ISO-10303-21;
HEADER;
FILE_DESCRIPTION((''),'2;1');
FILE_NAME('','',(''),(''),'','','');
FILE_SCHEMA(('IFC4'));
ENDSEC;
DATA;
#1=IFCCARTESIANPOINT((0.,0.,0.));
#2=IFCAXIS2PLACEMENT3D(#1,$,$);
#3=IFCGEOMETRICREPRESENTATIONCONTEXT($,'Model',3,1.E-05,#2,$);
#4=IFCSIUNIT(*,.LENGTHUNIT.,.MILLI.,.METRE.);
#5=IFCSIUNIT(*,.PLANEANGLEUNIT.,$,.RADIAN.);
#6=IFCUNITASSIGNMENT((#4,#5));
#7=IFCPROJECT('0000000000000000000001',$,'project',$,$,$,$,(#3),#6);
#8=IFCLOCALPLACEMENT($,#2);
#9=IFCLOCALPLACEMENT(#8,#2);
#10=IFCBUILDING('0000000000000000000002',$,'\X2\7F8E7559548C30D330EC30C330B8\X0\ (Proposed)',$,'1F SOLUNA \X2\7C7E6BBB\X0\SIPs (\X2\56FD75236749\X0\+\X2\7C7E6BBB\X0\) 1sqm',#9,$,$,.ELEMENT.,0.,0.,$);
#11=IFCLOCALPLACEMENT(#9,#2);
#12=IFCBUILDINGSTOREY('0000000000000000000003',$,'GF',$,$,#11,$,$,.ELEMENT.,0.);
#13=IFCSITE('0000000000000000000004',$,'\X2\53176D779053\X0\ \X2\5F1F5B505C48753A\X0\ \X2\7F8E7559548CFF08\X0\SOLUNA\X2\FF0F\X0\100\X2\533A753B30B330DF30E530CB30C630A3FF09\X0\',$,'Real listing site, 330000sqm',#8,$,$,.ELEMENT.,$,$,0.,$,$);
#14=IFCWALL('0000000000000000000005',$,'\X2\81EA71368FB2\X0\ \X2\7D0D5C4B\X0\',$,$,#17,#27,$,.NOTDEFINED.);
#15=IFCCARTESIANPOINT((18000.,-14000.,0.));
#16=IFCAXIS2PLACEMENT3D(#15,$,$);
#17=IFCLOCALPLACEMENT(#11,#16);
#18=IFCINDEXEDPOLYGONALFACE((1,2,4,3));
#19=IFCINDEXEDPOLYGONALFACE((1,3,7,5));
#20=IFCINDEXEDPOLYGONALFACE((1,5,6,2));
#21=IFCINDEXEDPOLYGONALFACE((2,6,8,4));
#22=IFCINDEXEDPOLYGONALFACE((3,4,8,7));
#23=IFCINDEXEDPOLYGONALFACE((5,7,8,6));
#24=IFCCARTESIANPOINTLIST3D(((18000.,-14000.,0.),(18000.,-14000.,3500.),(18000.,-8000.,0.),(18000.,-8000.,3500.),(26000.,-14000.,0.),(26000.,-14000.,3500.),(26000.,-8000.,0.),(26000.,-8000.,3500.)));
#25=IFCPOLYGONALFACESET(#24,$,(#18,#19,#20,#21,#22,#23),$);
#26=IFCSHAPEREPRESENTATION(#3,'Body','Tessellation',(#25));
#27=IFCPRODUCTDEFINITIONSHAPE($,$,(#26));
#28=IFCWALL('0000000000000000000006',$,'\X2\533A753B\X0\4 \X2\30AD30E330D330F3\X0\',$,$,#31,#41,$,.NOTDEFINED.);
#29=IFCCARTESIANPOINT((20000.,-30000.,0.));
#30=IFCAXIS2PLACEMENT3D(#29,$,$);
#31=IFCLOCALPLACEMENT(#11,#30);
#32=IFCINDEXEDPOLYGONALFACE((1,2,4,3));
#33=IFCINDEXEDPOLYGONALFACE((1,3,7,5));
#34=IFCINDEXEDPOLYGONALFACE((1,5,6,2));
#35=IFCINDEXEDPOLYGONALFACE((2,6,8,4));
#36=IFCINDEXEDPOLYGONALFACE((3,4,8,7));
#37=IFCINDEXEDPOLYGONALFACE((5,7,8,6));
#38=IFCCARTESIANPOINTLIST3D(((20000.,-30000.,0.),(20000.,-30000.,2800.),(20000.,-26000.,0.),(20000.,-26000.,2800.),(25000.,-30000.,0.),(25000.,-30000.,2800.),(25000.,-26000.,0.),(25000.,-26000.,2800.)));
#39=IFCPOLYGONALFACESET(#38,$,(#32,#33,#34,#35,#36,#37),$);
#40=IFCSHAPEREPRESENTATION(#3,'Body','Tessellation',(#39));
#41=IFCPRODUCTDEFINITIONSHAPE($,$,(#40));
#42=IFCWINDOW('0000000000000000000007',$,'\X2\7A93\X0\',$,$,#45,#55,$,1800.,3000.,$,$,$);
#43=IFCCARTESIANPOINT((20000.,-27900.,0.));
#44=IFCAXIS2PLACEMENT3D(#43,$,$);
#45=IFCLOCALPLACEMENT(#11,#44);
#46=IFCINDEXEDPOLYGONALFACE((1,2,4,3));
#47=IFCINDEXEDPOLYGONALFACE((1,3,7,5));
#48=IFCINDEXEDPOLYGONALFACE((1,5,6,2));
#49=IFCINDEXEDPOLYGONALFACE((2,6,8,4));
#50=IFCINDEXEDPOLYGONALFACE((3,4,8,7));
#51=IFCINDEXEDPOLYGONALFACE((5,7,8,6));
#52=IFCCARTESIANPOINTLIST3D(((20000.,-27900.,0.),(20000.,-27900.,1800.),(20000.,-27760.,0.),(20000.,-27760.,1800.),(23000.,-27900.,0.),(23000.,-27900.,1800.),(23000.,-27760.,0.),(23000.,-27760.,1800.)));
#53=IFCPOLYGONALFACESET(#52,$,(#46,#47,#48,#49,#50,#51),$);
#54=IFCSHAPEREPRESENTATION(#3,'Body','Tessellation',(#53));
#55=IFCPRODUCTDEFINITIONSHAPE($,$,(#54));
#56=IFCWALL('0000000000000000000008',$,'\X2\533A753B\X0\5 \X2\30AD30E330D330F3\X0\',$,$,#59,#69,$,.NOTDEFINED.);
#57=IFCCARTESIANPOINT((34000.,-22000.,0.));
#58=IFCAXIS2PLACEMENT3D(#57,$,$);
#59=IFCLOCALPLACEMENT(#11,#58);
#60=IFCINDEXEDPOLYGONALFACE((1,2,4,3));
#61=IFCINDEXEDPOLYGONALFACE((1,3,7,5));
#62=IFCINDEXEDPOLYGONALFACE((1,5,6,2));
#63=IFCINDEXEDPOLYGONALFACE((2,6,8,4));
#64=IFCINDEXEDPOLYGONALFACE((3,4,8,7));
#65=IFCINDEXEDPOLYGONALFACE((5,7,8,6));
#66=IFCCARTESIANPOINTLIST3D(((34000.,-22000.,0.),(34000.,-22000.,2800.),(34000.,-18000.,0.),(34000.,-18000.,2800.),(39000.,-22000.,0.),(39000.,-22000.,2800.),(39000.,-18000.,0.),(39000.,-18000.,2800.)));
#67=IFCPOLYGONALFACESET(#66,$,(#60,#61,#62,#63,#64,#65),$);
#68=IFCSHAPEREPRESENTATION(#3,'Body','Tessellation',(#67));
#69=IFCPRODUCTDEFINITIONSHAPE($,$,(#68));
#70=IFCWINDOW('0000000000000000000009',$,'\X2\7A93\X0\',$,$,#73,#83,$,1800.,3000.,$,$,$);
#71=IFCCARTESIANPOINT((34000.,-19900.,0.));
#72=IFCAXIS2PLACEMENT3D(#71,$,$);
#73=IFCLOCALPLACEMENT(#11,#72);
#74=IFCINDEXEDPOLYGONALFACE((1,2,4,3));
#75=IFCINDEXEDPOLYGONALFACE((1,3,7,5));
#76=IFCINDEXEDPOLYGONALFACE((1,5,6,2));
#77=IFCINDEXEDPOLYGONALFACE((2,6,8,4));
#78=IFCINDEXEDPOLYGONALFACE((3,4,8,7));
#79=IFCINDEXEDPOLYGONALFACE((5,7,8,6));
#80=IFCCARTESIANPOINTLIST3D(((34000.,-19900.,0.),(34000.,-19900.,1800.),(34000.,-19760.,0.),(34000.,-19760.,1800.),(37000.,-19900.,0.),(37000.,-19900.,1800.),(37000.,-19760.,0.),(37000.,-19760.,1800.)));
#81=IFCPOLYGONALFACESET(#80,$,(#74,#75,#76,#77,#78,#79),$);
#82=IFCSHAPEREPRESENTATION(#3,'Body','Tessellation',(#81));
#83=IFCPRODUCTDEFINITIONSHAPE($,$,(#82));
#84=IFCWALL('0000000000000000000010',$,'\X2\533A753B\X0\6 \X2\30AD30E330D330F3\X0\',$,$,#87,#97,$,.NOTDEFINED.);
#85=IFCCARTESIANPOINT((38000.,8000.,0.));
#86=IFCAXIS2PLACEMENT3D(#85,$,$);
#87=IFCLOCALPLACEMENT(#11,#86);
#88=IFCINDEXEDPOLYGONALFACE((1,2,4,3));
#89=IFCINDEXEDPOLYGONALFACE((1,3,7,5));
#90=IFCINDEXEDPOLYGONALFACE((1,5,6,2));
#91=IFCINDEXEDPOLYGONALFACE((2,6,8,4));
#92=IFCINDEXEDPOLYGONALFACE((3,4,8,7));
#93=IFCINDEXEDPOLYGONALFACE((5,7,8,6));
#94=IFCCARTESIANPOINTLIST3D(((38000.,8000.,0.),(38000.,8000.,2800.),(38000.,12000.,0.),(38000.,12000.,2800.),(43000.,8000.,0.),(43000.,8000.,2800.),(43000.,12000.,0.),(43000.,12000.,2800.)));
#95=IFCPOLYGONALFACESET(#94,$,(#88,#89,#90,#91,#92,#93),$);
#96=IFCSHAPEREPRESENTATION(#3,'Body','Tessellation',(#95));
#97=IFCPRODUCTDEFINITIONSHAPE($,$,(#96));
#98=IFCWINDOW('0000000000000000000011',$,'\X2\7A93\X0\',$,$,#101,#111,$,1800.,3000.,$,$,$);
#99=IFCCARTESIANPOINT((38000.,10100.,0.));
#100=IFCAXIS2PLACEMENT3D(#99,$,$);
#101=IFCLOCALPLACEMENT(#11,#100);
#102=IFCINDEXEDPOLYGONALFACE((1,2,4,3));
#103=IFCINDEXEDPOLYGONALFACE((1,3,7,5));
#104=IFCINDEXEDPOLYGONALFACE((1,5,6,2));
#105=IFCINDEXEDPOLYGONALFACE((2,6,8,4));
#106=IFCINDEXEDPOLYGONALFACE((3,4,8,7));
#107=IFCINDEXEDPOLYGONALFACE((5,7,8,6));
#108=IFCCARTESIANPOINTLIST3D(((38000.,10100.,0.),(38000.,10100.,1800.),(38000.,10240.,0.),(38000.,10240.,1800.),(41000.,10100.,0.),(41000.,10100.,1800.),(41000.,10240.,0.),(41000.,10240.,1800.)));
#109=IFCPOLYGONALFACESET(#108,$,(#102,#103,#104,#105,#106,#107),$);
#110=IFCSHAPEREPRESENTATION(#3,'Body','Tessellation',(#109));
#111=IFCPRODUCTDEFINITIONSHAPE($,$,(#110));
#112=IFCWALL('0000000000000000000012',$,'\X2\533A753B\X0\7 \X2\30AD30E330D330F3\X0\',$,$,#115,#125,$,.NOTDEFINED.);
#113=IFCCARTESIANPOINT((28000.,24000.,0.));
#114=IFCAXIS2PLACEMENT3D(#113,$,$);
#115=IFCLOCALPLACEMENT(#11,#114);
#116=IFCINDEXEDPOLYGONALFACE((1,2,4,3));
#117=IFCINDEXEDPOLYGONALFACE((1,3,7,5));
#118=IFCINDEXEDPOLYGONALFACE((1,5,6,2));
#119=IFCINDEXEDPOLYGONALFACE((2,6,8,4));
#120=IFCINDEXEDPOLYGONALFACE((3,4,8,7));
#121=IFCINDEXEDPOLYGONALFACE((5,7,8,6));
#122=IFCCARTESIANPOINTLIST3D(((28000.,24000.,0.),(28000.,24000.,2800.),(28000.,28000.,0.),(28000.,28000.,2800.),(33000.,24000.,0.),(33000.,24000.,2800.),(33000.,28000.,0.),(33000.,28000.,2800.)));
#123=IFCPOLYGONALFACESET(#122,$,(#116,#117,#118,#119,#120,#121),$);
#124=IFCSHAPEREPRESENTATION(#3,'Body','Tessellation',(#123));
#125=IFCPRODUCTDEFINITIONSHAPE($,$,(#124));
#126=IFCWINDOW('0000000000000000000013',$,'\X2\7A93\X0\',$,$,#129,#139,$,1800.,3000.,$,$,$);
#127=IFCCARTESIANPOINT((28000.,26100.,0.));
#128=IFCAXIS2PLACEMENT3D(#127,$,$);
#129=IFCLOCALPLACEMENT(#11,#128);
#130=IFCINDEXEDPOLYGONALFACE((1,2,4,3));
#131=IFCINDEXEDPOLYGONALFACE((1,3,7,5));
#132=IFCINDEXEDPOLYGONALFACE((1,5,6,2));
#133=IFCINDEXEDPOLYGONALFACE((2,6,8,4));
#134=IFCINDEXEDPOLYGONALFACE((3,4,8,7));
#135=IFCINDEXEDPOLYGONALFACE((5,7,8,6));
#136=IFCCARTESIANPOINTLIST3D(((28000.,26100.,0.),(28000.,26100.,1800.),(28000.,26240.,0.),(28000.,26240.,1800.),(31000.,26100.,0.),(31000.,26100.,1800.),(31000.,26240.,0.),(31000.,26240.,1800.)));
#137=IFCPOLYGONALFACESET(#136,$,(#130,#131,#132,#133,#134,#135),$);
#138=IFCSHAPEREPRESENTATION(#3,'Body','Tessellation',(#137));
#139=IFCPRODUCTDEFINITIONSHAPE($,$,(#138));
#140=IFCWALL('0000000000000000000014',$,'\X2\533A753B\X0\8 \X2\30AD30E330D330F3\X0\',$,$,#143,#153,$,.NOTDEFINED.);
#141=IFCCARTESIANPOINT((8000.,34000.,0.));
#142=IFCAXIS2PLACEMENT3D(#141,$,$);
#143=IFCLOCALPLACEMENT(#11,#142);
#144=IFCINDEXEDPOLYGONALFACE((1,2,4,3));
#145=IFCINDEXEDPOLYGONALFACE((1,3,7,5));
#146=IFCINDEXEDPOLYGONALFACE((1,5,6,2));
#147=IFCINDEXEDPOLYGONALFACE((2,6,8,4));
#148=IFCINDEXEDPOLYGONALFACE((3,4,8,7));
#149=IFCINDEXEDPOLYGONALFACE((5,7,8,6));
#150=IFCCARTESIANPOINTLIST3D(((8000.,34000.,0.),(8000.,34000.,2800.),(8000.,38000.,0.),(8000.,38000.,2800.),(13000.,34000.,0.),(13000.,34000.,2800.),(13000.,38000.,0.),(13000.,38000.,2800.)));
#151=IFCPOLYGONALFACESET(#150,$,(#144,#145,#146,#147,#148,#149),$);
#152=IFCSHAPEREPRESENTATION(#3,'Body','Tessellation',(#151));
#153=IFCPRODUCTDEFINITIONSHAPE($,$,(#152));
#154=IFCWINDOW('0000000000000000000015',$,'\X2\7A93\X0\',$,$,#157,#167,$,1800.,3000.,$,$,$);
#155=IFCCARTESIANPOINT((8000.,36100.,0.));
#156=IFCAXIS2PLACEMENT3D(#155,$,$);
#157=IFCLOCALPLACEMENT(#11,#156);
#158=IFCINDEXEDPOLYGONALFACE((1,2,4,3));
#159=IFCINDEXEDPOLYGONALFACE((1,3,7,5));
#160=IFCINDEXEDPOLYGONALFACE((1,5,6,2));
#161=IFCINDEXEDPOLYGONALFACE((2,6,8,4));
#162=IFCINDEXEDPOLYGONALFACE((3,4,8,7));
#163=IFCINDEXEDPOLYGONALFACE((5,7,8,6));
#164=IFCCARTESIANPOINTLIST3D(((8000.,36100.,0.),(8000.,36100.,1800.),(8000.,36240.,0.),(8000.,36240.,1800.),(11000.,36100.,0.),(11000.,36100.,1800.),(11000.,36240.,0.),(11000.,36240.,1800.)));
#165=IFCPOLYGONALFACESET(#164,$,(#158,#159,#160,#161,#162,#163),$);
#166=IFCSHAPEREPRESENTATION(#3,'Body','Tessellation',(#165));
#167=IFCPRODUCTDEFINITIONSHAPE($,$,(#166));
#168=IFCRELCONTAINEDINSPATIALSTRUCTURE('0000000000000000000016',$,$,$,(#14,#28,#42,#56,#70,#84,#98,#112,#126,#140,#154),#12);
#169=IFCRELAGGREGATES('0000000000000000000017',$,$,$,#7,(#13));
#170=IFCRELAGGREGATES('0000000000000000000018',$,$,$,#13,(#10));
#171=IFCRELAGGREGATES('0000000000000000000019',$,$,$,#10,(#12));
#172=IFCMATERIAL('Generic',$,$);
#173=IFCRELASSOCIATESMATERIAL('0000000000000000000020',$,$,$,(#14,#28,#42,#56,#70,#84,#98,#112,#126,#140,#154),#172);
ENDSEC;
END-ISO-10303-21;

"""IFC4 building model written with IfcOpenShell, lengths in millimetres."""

from ifc_helpers import new_model, si_unit, frame, frame_2d, origin, place, context, project, spatial, rectangle, extrude, material, element, fill, save


model = new_model("IFC4")

# Units and contexts
model_context = context("Model", 3, precision=1e-05, world=origin())
ifc_project = project(units=[si_unit("LENGTHUNIT", "METRE", prefix="MILLI"), si_unit("PLANEANGLEUNIT", "RADIAN")], contexts=[model_context])

# Site, building, storey
site_placement = place(None, origin())
site = spatial("IfcSite", under=ifc_project, at=site_placement, Name="北海道 弟子屈町 美留和（SOLUNA／100区画コミュニティ）", ObjectType="Real listing site, 330000sqm", CompositionType="ELEMENT", RefElevation=0.0)
building_placement = place(site_placement, origin())
building = spatial("IfcBuilding", under=site, at=building_placement, Name="美留和ビレッジ (Proposed)", ObjectType="1F SOLUNA 籾殻SIPs (国産杉+籾殻) 1sqm", CompositionType="ELEMENT", ElevationOfRefHeight=0.0, ElevationOfTerrain=0.0)
storey_placement = place(building_placement, origin())
storey = spatial("IfcBuildingStorey", under=building, at=storey_placement, Name="GF", CompositionType="ELEMENT", Elevation=0.0)

# Wall
ifc_material_1 = material(Name="Generic")
wall_1_placement = place(storey_placement, frame((18000.0, -14000.0, 0.0)))
element("IfcWall", 1, at=wall_1_placement, inside=storey, material=ifc_material_1, Name="自然農 納屋", PredefinedType="NOTDEFINED", context=model_context, shape_type="SweptSolid", body=[
    extrude(rectangle(XDim=8000.0, YDim=6000.0, at=frame_2d((4000.0, 3000.0))), frame((18000.0, -14000.0, 0.0)), (0.0, 0.0, 1.0), 3500.0),
])

# Walls, openings, windows
wall_2_placement = place(storey_placement, frame((20000.0, -30000.0, 0.0)))
wall_2 = element("IfcWall", 2, at=wall_2_placement, inside=storey, material=ifc_material_1, Name="区画4 キャビン", PredefinedType="NOTDEFINED", context=model_context, shape_type="SweptSolid", body=[
    extrude(rectangle(XDim=5000.0, YDim=4000.0, at=frame_2d((2500.0, 2000.0))), frame((20000.0, -30000.0, 0.0)), (0.0, 0.0, 1.0), 2800.0),
])
opening_1_placement = place(storey_placement, frame((20000.0, -27900.0, 0.0)))
opening_1 = element("IfcOpeningElement", 3, at=opening_1_placement, cuts=wall_2, PredefinedType="NOTDEFINED", context=model_context, shape_type="SweptSolid", body=[
    extrude(rectangle(XDim=3000.0, YDim=140.0, at=frame_2d((1500.0, 70.0))), frame((20000.0, -27900.0, 0.0)), (0.0, 0.0, 1.0), 1800.0),
])
window_1_placement = place(storey_placement, frame((20000.0, -27900.0, 0.0)))
window_1 = element("IfcWindow", 4, at=window_1_placement, inside=storey, material=ifc_material_1, Name="窓", OverallHeight=1800.0, OverallWidth=3000.0, context=model_context, shape_type="SweptSolid", body=[
    extrude(rectangle(XDim=3000.0, YDim=140.0, at=frame_2d((1500.0, 70.0))), frame((20000.0, -27900.0, 0.0)), (0.0, 0.0, 1.0), 1800.0),
])
fill(opening_1, window_1)
wall_3_placement = place(storey_placement, frame((34000.0, -22000.0, 0.0)))
wall_3 = element("IfcWall", 5, at=wall_3_placement, inside=storey, material=ifc_material_1, Name="区画5 キャビン", PredefinedType="NOTDEFINED", context=model_context, shape_type="SweptSolid", body=[
    extrude(rectangle(XDim=5000.0, YDim=4000.0, at=frame_2d((2500.0, 2000.0))), frame((34000.0, -22000.0, 0.0)), (0.0, 0.0, 1.0), 2800.0),
])
opening_2_placement = place(storey_placement, frame((34000.0, -19900.0, 0.0)))
opening_2 = element("IfcOpeningElement", 6, at=opening_2_placement, cuts=wall_3, PredefinedType="NOTDEFINED", context=model_context, shape_type="SweptSolid", body=[
    extrude(rectangle(XDim=3000.0, YDim=140.0, at=frame_2d((1500.0, 70.0))), frame((34000.0, -19900.0, 0.0)), (0.0, 0.0, 1.0), 1800.0),
])
window_2_placement = place(storey_placement, frame((34000.0, -19900.0, 0.0)))
window_2 = element("IfcWindow", 7, at=window_2_placement, inside=storey, material=ifc_material_1, Name="窓", OverallHeight=1800.0, OverallWidth=3000.0, context=model_context, shape_type="SweptSolid", body=[
    extrude(rectangle(XDim=3000.0, YDim=140.0, at=frame_2d((1500.0, 70.0))), frame((34000.0, -19900.0, 0.0)), (0.0, 0.0, 1.0), 1800.0),
])
fill(opening_2, window_2)
wall_4_placement = place(storey_placement, frame((38000.0, 8000.0, 0.0)))
wall_4 = element("IfcWall", 8, at=wall_4_placement, inside=storey, material=ifc_material_1, Name="区画6 キャビン", PredefinedType="NOTDEFINED", context=model_context, shape_type="SweptSolid", body=[
    extrude(rectangle(XDim=5000.0, YDim=4000.0, at=frame_2d((2500.0, 2000.0))), frame((38000.0, 8000.0, 0.0)), (0.0, 0.0, 1.0), 2800.0),
])
opening_3_placement = place(storey_placement, frame((38000.0, 10100.0, 0.0)))
opening_3 = element("IfcOpeningElement", 9, at=opening_3_placement, cuts=wall_4, PredefinedType="NOTDEFINED", context=model_context, shape_type="SweptSolid", body=[
    extrude(rectangle(XDim=3000.0, YDim=140.0, at=frame_2d((1500.0, 70.0))), frame((38000.0, 10100.0, 0.0)), (0.0, 0.0, 1.0), 1800.0),
])
window_3_placement = place(storey_placement, frame((38000.0, 10100.0, 0.0)))
window_3 = element("IfcWindow", 10, at=window_3_placement, inside=storey, material=ifc_material_1, Name="窓", OverallHeight=1800.0, OverallWidth=3000.0, context=model_context, shape_type="SweptSolid", body=[
    extrude(rectangle(XDim=3000.0, YDim=140.0, at=frame_2d((1500.0, 70.0))), frame((38000.0, 10100.0, 0.0)), (0.0, 0.0, 1.0), 1800.0),
])
fill(opening_3, window_3)
wall_5_placement = place(storey_placement, frame((28000.0, 24000.0, 0.0)))
wall_5 = element("IfcWall", 11, at=wall_5_placement, inside=storey, material=ifc_material_1, Name="区画7 キャビン", PredefinedType="NOTDEFINED", context=model_context, shape_type="SweptSolid", body=[
    extrude(rectangle(XDim=5000.0, YDim=4000.0, at=frame_2d((2500.0, 2000.0))), frame((28000.0, 24000.0, 0.0)), (0.0, 0.0, 1.0), 2800.0),
])
opening_4_placement = place(storey_placement, frame((28000.0, 26100.0, 0.0)))
opening_4 = element("IfcOpeningElement", 12, at=opening_4_placement, cuts=wall_5, PredefinedType="NOTDEFINED", context=model_context, shape_type="SweptSolid", body=[
    extrude(rectangle(XDim=3000.0, YDim=140.0, at=frame_2d((1500.0, 70.0))), frame((28000.0, 26100.0, 0.0)), (0.0, 0.0, 1.0), 1800.0),
])
window_4_placement = place(storey_placement, frame((28000.0, 26100.0, 0.0)))
window_4 = element("IfcWindow", 13, at=window_4_placement, inside=storey, material=ifc_material_1, Name="窓", OverallHeight=1800.0, OverallWidth=3000.0, context=model_context, shape_type="SweptSolid", body=[
    extrude(rectangle(XDim=3000.0, YDim=140.0, at=frame_2d((1500.0, 70.0))), frame((28000.0, 26100.0, 0.0)), (0.0, 0.0, 1.0), 1800.0),
])
fill(opening_4, window_4)
wall_6_placement = place(storey_placement, frame((8000.0, 34000.0, 0.0)))
wall_6 = element("IfcWall", 14, at=wall_6_placement, inside=storey, material=ifc_material_1, Name="区画8 キャビン", PredefinedType="NOTDEFINED", context=model_context, shape_type="SweptSolid", body=[
    extrude(rectangle(XDim=5000.0, YDim=4000.0, at=frame_2d((2500.0, 2000.0))), frame((8000.0, 34000.0, 0.0)), (0.0, 0.0, 1.0), 2800.0),
])
opening_5_placement = place(storey_placement, frame((8000.0, 36100.0, 0.0)))
opening_5 = element("IfcOpeningElement", 15, at=opening_5_placement, cuts=wall_6, PredefinedType="NOTDEFINED", context=model_context, shape_type="SweptSolid", body=[
    extrude(rectangle(XDim=3000.0, YDim=140.0, at=frame_2d((1500.0, 70.0))), frame((8000.0, 36100.0, 0.0)), (0.0, 0.0, 1.0), 1800.0),
])
window_5_placement = place(storey_placement, frame((8000.0, 36100.0, 0.0)))
window_5 = element("IfcWindow", 16, at=window_5_placement, inside=storey, material=ifc_material_1, Name="窓", OverallHeight=1800.0, OverallWidth=3000.0, context=model_context, shape_type="SweptSolid", body=[
    extrude(rectangle(XDim=3000.0, YDim=140.0, at=frame_2d((1500.0, 70.0))), frame((8000.0, 36100.0, 0.0)), (0.0, 0.0, 1.0), 1800.0),
])
fill(opening_5, window_5)

save(model, "model.ifc")
